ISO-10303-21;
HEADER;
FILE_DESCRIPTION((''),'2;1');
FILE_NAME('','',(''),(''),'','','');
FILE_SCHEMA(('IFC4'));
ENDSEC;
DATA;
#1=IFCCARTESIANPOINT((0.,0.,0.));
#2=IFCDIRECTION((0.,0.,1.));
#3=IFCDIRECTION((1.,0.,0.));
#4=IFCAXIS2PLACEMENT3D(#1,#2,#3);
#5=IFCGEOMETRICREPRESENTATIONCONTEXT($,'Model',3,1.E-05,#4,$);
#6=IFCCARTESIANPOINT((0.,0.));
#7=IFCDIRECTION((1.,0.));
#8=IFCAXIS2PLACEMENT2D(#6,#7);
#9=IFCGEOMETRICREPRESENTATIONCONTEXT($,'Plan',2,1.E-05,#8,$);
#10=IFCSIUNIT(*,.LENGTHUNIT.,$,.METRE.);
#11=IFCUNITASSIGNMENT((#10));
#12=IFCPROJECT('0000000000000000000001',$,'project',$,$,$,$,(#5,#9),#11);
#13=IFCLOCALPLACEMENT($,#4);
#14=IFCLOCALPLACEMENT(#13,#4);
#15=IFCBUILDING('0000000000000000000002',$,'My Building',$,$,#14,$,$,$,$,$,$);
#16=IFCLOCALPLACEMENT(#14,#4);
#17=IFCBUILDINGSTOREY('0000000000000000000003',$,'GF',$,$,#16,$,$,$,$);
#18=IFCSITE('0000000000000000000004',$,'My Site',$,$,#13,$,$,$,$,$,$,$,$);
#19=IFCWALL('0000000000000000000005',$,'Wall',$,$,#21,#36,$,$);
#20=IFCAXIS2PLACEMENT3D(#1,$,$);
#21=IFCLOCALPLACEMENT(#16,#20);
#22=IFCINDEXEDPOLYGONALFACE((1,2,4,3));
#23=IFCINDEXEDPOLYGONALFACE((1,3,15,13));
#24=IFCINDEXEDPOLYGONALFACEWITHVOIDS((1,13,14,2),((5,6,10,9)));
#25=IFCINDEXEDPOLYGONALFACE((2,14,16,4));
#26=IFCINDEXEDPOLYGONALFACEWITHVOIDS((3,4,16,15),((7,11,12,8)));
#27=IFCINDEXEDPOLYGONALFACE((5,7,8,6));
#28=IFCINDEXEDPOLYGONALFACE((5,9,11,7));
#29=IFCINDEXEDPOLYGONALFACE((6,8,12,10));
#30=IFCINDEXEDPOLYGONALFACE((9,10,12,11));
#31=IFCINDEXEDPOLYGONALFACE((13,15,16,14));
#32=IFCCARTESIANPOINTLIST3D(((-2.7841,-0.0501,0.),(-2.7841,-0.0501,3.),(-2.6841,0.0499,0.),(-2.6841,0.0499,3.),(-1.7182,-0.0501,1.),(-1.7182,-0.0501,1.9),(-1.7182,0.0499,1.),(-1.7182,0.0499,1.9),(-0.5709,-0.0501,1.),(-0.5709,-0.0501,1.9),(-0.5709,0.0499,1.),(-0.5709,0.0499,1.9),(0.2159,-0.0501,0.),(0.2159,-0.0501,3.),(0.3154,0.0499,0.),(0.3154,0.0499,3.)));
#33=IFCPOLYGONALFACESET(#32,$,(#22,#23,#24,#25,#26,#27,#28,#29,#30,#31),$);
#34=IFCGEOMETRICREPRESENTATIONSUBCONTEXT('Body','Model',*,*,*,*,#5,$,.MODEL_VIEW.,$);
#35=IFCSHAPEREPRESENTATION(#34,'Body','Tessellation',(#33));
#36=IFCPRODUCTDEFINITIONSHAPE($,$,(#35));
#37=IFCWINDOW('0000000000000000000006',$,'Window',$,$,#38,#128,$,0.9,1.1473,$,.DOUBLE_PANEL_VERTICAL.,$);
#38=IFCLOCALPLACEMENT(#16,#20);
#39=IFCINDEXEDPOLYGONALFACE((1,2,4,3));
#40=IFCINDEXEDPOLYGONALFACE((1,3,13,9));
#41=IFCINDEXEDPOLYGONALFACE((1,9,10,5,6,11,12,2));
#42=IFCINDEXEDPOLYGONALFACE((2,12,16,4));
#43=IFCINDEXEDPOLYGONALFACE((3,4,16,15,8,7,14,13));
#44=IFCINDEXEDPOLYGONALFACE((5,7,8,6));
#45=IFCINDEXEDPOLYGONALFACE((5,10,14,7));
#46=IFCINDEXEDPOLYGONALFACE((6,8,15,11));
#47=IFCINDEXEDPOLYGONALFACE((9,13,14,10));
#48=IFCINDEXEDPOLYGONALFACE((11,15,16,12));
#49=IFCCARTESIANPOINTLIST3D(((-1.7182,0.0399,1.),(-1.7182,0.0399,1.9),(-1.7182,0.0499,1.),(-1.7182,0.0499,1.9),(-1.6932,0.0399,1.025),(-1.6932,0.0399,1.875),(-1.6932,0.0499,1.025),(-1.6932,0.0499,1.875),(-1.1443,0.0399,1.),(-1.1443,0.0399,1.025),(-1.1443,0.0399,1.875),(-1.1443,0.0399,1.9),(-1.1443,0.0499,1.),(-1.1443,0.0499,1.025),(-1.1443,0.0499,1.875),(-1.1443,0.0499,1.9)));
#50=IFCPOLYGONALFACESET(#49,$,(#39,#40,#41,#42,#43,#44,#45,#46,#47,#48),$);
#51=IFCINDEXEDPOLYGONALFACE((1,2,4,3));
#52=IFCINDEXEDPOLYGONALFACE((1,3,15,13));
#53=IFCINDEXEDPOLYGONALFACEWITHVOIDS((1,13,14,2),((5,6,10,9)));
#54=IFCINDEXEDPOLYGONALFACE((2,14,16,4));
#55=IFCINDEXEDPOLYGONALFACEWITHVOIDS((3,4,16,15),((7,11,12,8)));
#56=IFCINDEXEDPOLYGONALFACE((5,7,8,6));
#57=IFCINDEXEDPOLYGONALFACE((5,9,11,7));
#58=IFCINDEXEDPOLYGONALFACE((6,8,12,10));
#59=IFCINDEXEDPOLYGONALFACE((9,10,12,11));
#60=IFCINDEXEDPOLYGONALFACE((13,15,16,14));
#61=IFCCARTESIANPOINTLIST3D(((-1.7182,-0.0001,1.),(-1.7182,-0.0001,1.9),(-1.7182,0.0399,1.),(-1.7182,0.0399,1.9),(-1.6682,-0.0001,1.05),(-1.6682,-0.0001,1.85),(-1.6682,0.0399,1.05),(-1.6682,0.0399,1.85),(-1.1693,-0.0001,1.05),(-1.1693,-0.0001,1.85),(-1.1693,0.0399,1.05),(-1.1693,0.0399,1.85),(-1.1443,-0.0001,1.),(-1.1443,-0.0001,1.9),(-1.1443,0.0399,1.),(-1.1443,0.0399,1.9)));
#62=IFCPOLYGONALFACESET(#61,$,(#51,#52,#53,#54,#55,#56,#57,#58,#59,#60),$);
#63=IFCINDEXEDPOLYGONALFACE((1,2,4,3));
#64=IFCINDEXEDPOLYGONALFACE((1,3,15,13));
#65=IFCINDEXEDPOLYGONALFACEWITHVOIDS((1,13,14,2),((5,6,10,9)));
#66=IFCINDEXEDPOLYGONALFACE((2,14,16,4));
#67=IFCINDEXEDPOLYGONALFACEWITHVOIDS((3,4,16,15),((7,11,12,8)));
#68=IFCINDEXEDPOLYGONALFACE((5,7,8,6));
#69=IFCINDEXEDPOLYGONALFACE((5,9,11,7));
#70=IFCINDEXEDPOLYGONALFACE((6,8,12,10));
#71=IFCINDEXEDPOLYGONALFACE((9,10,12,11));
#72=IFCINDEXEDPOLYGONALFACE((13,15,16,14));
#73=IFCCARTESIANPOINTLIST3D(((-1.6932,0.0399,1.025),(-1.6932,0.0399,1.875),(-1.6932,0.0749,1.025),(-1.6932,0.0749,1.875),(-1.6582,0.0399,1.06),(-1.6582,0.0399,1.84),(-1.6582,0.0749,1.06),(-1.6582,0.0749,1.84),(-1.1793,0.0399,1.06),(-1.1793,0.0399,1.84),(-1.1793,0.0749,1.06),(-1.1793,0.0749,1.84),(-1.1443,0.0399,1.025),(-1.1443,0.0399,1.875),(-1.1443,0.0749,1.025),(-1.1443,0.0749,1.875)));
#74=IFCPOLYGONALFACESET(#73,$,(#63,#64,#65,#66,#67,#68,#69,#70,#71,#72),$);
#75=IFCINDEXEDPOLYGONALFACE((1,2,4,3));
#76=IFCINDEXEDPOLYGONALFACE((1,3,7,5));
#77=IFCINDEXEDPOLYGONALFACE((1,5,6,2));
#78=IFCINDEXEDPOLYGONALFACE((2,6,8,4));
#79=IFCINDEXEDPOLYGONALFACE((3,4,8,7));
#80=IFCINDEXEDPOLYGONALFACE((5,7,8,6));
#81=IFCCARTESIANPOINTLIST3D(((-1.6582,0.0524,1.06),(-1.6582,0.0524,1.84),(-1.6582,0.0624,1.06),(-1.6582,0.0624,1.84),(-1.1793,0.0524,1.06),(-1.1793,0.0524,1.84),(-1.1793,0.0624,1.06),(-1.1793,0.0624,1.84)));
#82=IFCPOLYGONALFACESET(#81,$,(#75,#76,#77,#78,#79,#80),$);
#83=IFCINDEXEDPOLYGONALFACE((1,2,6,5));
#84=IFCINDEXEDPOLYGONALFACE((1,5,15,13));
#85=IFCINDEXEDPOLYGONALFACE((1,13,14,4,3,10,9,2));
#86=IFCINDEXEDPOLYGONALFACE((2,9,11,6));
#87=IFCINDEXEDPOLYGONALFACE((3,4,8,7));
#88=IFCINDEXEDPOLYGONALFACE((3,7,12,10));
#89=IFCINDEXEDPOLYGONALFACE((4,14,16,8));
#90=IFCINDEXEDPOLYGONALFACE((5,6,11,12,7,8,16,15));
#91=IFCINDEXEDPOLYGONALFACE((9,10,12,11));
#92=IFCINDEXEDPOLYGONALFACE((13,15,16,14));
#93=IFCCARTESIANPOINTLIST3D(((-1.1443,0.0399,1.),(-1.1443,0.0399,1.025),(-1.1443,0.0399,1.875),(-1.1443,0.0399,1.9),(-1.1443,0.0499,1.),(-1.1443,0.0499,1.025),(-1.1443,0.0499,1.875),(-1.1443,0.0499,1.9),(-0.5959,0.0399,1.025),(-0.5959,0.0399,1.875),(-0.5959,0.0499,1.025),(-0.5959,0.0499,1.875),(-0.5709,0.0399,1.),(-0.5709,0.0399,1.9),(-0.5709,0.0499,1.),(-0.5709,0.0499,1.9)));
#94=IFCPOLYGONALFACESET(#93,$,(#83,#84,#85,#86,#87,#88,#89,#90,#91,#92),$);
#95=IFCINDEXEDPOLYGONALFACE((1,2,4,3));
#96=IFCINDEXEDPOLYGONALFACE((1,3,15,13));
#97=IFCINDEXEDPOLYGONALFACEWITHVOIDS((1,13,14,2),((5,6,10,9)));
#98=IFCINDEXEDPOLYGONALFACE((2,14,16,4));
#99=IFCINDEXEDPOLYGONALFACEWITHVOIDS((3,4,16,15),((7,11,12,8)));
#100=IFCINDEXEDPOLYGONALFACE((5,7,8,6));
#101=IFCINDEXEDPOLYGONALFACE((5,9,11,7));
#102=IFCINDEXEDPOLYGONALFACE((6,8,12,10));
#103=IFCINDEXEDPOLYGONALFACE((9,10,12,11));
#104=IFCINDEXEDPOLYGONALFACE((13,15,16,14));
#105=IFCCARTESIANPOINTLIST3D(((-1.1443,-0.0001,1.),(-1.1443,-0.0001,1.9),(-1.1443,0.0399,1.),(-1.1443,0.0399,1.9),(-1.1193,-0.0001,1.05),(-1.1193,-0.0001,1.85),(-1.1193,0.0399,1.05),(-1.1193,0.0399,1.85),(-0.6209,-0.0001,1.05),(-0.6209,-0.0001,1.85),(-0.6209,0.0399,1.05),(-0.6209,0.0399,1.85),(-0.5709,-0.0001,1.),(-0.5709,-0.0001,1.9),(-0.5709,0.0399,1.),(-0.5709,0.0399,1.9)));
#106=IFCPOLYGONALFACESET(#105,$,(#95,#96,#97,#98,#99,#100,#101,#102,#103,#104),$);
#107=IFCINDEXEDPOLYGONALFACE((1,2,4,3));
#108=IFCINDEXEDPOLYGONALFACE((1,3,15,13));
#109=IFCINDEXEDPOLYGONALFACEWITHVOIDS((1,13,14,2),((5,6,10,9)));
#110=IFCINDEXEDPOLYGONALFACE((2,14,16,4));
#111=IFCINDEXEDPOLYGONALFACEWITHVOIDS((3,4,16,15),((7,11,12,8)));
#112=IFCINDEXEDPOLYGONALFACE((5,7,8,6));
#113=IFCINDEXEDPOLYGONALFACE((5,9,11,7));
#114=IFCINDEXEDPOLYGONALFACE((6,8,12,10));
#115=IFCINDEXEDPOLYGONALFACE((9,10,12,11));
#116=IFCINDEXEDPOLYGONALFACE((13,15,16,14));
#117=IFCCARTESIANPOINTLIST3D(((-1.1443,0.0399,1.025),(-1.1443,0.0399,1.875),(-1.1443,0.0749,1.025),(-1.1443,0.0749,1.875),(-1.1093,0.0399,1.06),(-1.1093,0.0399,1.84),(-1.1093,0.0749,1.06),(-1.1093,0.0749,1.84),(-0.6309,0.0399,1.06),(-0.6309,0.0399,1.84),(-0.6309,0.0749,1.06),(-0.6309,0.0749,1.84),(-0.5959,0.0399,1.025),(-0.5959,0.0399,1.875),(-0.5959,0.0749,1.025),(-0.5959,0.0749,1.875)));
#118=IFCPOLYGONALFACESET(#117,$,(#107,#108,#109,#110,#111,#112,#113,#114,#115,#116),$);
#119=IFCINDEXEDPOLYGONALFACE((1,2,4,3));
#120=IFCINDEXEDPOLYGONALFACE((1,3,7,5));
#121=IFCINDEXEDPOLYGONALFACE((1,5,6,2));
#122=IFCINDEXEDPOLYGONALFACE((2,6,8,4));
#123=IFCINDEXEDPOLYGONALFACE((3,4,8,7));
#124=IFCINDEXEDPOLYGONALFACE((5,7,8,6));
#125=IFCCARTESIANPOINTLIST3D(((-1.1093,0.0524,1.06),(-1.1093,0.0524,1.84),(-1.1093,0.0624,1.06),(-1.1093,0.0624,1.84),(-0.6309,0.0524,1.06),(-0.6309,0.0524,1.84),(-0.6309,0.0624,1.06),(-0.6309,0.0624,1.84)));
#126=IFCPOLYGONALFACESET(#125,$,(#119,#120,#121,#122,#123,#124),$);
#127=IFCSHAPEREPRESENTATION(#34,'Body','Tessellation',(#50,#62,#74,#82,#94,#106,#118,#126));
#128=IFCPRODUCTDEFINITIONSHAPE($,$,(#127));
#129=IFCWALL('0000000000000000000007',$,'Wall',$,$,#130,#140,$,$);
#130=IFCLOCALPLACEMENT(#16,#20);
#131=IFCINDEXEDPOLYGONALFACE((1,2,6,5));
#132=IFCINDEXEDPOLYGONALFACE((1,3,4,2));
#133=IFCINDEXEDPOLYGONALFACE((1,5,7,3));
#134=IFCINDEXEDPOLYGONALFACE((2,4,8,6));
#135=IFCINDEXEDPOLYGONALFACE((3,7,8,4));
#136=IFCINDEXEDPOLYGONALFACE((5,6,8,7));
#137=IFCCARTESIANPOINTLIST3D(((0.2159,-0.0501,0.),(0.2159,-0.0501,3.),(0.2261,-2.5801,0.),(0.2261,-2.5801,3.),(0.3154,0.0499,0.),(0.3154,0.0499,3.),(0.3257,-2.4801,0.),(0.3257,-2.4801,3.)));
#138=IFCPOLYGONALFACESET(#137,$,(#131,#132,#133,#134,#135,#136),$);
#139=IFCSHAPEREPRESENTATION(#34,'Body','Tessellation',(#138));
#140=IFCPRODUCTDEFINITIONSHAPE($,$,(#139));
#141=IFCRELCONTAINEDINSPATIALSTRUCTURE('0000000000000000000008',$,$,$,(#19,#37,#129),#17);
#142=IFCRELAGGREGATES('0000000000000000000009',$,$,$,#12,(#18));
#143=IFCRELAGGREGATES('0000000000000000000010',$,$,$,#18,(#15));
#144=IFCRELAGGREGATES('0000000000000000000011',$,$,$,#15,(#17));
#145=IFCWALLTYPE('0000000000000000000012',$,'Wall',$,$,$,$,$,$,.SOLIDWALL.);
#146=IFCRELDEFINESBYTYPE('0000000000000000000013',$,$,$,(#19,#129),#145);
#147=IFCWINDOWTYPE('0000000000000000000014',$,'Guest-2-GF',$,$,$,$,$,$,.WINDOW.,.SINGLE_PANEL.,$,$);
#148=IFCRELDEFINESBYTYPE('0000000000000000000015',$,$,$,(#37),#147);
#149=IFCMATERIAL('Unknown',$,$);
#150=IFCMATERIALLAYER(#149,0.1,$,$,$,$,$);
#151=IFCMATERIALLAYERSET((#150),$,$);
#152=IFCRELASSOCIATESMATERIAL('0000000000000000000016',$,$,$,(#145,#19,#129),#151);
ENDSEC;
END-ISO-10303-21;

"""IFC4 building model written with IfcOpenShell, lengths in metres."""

from ifc_helpers import new_model, entity, si_unit, frame, origin_with_axes, origin_2d_with_axis, place, context, subcontext, project, spatial, line, indexed_curve, outline, extrude, shape, source, transform, mapped, material, layer, layer_set, layer_usage, type_object, type_shapes, element, fill, save


model = new_model("IFC4")

# Units and contexts
model_context = context("Model", 3, precision=1e-05, world=origin_with_axes())
plan_context = context("Plan", 2, precision=1e-05, world=origin_2d_with_axis())
body_context_1 = subcontext(model_context, "Body", "Model", "MODEL_VIEW")
body_context_2 = subcontext(plan_context, "Body", "Plan", "PLAN_VIEW")
ifc_project = project(units=[si_unit("LENGTHUNIT", "METRE")], contexts=[model_context, plan_context])

# Site, building, storey
site_placement = place(None, origin_with_axes())
site = spatial("IfcSite", under=ifc_project, at=site_placement, Name="My Site")
building_placement = place(site_placement, origin_with_axes())
building = spatial("IfcBuilding", under=site, at=building_placement, Name="My Building")
storey_placement = place(building_placement, origin_with_axes())
storey = spatial("IfcBuildingStorey", under=building, at=storey_placement, Name="GF")

# Shared definitions
ifc_material = material(Name="Unknown")

# Shared definitions
ifc_layer_1 = layer(ifc_material, 0.1)
ifc_layer_set_1 = layer_set([ifc_layer_1])
wall_type = type_object("IfcWallType", Name="Wall", PredefinedType="SOLIDWALL", material=ifc_layer_set_1)

# Wall, opening, window
ifc_layer_usage_1 = layer_usage(ifc_layer_set_1, "AXIS2", "POSITIVE", 0.0)
wall_1_placement = place(storey_placement, frame((-2.7841, -0.0501, 0.0), z_axis=(0.0, 0.0, 1.0), x_axis=(1.0, 0.0, 0.0)))
wall_1 = element("IfcWall", 1, at=wall_1_placement, inside=storey, type_object=wall_type, material=ifc_layer_usage_1, Name="Wall", context=body_context_1, shape_type="SweptSolid", body=[
    extrude(outline(indexed_curve([(0.0, 0.0), (0.1, 0.1), (3.0996, 0.1), (3.0, 0.0)], segments=[line(1, 2, 3, 4, 1)])), origin_with_axes(), (0.0, 0.0, 1.0), 3.0),
])
shared_shape_1 = source(origin_with_axes(), body_context_1, "Body", "SweptSolid", [
    extrude(outline(indexed_curve([(0.0, 0.0), (1.1473, 0.0), (1.1473, 0.9), (0.0, 0.9)], segments=[line(1, 2, 3, 4, 1)])), frame((0.0, -0.6, 0.0), z_axis=(0.0, -1.0, 0.0), x_axis=(1.0, 0.0, 0.0)), (0.0, 0.0, -1.0), 1.2),
])
opening_1_placement = place(wall_1_placement, frame((1.066, 0.0, 1.0), z_axis=(0.0, 0.0, 1.0), x_axis=(1.0, 0.0, 0.0)))
opening_1 = element("IfcOpeningElement", 2, at=opening_1_placement, cuts=wall_1, PredefinedType="OPENING", context=body_context_1, shape_type="MappedRepresentation", body=[
    mapped(shared_shape_1, transform((0.0, 0.0, 0.0), x_axis=(1.0, 0.0, 0.0), y_axis=(0.0, 1.0, 0.0), z_axis=(0.0, 0.0, 1.0), scale=1.0)),
])
window_type_1 = type_object("IfcWindowType", Name="Guest-2-GF", PartitioningType="SINGLE_PANEL", PredefinedType="WINDOW")
shared_shape_2 = source(origin_with_axes(), body_context_1, "Body", "SweptSolid", [
    extrude(outline(indexed_curve([(0.5739, 0.0), (0.0, 0.0), (0.0, 0.9), (0.5739, 0.9), (0.5739, 0.875), (0.025, 0.875), (0.025, 0.025), (0.5739, 0.025)], segments=[line(1, 2, 3, 4, 5, 6, 7, 8, 1)])), frame((0.0, 0.09, 0.0), z_axis=(0.0, -1.0, 0.0), x_axis=(1.0, 0.0, 0.0)), (0.0, 0.0, -1.0), 0.01),
    extrude(outline(indexed_curve([(0.0, 0.0), (0.5739, 0.0), (0.5739, 0.9), (0.0, 0.9)], segments=[line(1, 2, 3, 4, 1)]), holes=[indexed_curve([(0.05, 0.05), (0.5489, 0.05), (0.5489, 0.85), (0.05, 0.85)], segments=[line(1, 2, 3, 4, 1)])]), frame((0.0, 0.05, 0.0), z_axis=(0.0, -1.0, 0.0), x_axis=(1.0, 0.0, 0.0)), (0.0, 0.0, -1.0), 0.04),
    extrude(outline(indexed_curve([(0.0, 0.0), (0.5489, 0.0), (0.5489, 0.85), (0.0, 0.85)], segments=[line(1, 2, 3, 4, 1)]), holes=[indexed_curve([(0.035, 0.035), (0.5139, 0.035), (0.5139, 0.815), (0.035, 0.815)], segments=[line(1, 2, 3, 4, 1)])]), frame((0.025, 0.09, 0.025), z_axis=(0.0, -1.0, 0.0), x_axis=(1.0, 0.0, 0.0)), (0.0, 0.0, -1.0), 0.035),
    extrude(outline(indexed_curve([(0.035, 0.035), (0.5139, 0.035), (0.5139, 0.815), (0.035, 0.815)], segments=[line(1, 2, 3, 4, 1)])), frame((0.025, 0.1025, 0.025), z_axis=(0.0, -1.0, 0.0), x_axis=(1.0, 0.0, 0.0)), (0.0, 0.0, -1.0), 0.01),
    extrude(outline(indexed_curve([(0.0, 0.9), (0.5733, 0.9), (0.5733, 0.0), (0.0, 0.0), (0.0, 0.025), (0.5483, 0.025), (0.5483, 0.875), (0.0, 0.875)], segments=[line(1, 2, 3, 4, 5, 6, 7, 8, 1)])), frame((0.5739, 0.09, 0.0), z_axis=(0.0, -1.0, 0.0), x_axis=(1.0, 0.0, 0.0)), (0.0, 0.0, -1.0), 0.01),
    extrude(outline(indexed_curve([(0.0, 0.0), (0.5733, 0.0), (0.5733, 0.9), (0.0, 0.9)], segments=[line(1, 2, 3, 4, 1)]), holes=[indexed_curve([(0.025, 0.05), (0.5233, 0.05), (0.5233, 0.85), (0.025, 0.85)], segments=[line(1, 2, 3, 4, 1)])]), frame((0.5739, 0.05, 0.0), z_axis=(0.0, -1.0, 0.0), x_axis=(1.0, 0.0, 0.0)), (0.0, 0.0, -1.0), 0.04),
    extrude(outline(indexed_curve([(0.0, 0.0), (0.5483, 0.0), (0.5483, 0.85), (0.0, 0.85)], segments=[line(1, 2, 3, 4, 1)]), holes=[indexed_curve([(0.035, 0.035), (0.5133, 0.035), (0.5133, 0.815), (0.035, 0.815)], segments=[line(1, 2, 3, 4, 1)])]), frame((0.5739, 0.09, 0.025), z_axis=(0.0, -1.0, 0.0), x_axis=(1.0, 0.0, 0.0)), (0.0, 0.0, -1.0), 0.035),
    extrude(outline(indexed_curve([(0.035, 0.035), (0.5133, 0.035), (0.5133, 0.815), (0.035, 0.815)], segments=[line(1, 2, 3, 4, 1)])), frame((0.5739, 0.1025, 0.025), z_axis=(0.0, -1.0, 0.0), x_axis=(1.0, 0.0, 0.0)), (0.0, 0.0, -1.0), 0.01),
])
shared_shape_3 = source(origin_with_axes(), body_context_2, "Body", "Curve2D", [
    entity("IfcIndexedPolyCurve", entity("IfcCartesianPointList2D", [[0.05, 0.05], [0.5489, 0.05]])),
    entity("IfcIndexedPolyCurve", entity("IfcCartesianPointList2D", [[0.0, 0.1], [0.025, 0.1], [0.025, 0.09], [0.05, 0.09], [0.05, 0.05], [0.0, 0.05]]), [entity("IfcLineIndex", [1, 2, 3, 4, 5, 6, 1])]),
    entity("IfcIndexedPolyCurve", entity("IfcCartesianPointList2D", [[0.5739, 0.1], [0.5739, 0.1], [0.5739, 0.09], [0.5489, 0.09], [0.5489, 0.05], [0.5739, 0.05]])),
    entity("IfcIndexedPolyCurve", entity("IfcCartesianPointList2D", [[0.025, 0.09], [0.06, 0.09], [0.06, 0.125], [0.025, 0.125]]), [entity("IfcLineIndex", [1, 2, 3, 4, 1])]),
    entity("IfcIndexedPolyCurve", entity("IfcCartesianPointList2D", [[0.5739, 0.09], [0.5389, 0.09], [0.5389, 0.125], [0.5739, 0.125]]), [entity("IfcLineIndex", [1, 2, 3, 4, 1])]),
    entity("IfcIndexedPolyCurve", entity("IfcCartesianPointList2D", [[0.06, 0.09], [0.5389, 0.09]])),
    entity("IfcIndexedPolyCurve", entity("IfcCartesianPointList2D", [[0.06, 0.125], [0.5389, 0.125]])),
    entity("IfcIndexedPolyCurve", entity("IfcCartesianPointList2D", [[0.06, 0.1075], [0.5389, 0.1075]])),
    entity("IfcIndexedPolyCurve", entity("IfcCartesianPointList2D", [[0.5989, 0.05], [1.0973, 0.05]])),
    entity("IfcIndexedPolyCurve", entity("IfcCartesianPointList2D", [[0.5739, 0.1], [0.5739, 0.1], [0.5739, 0.09], [0.5989, 0.09], [0.5989, 0.05], [0.5739, 0.05]])),
    entity("IfcIndexedPolyCurve", entity("IfcCartesianPointList2D", [[1.1473, 0.1], [1.1223, 0.1], [1.1223, 0.09], [1.0973, 0.09], [1.0973, 0.05], [1.1473, 0.05]]), [entity("IfcLineIndex", [1, 2, 3, 4, 5, 6, 1])]),
    entity("IfcIndexedPolyCurve", entity("IfcCartesianPointList2D", [[0.5739, 0.09], [0.6089, 0.09], [0.6089, 0.125], [0.5739, 0.125]]), [entity("IfcLineIndex", [1, 2, 3, 4, 1])]),
    entity("IfcIndexedPolyCurve", entity("IfcCartesianPointList2D", [[1.1223, 0.09], [1.0873, 0.09], [1.0873, 0.125], [1.1223, 0.125]]), [entity("IfcLineIndex", [1, 2, 3, 4, 1])]),
    entity("IfcIndexedPolyCurve", entity("IfcCartesianPointList2D", [[0.6089, 0.09], [1.0873, 0.09]])),
    entity("IfcIndexedPolyCurve", entity("IfcCartesianPointList2D", [[0.6089, 0.125], [1.0873, 0.125]])),
    entity("IfcIndexedPolyCurve", entity("IfcCartesianPointList2D", [[0.6089, 0.1075], [1.0873, 0.1075]])),
])
type_shapes(window_type_1, [shared_shape_2, shared_shape_3])
window_1_placement = place(opening_1_placement, origin_with_axes())
window_1 = element("IfcWindow", 3, at=window_1_placement, inside=storey, type_object=window_type_1, Name="Window", OverallHeight=0.9, OverallWidth=1.1473, PartitioningType="DOUBLE_PANEL_VERTICAL", shapes=[
    shape(body_context_1, "Body", "MappedRepresentation", [mapped(shared_shape_2, transform((0.0, 0.0, 0.0), x_axis=(1.0, 0.0, 0.0), y_axis=(0.0, 1.0, 0.0), z_axis=(0.0, 0.0, 1.0), scale=1.0))]),
    shape(body_context_2, "Body", "MappedRepresentation", [mapped(shared_shape_3, transform((0.0, 0.0, 0.0), x_axis=(1.0, 0.0, 0.0), y_axis=(0.0, 1.0, 0.0), z_axis=(0.0, 0.0, 1.0), scale=1.0))]),
])
fill(opening_1, window_1)

# Wall
ifc_layer_usage_2 = layer_usage(ifc_layer_set_1, "AXIS2", "POSITIVE", 0.0)
wall_2_placement = place(storey_placement, frame((0.2159, -0.0501, 0.0), z_axis=(0.0, 0.0, 1.0), x_axis=(0.004067, -0.999992, 0.0)))
element("IfcWall", 4, at=wall_2_placement, inside=storey, type_object=wall_type, material=ifc_layer_usage_2, Name="Wall", context=body_context_1, shape_type="SweptSolid", body=[
    extrude(outline(indexed_curve([(0.0, 0.0), (-0.0996, 0.1), (2.4304, 0.1), (2.53, 0.0)], segments=[line(1, 2, 3, 4, 1)])), origin_with_axes(), (0.0, 0.0, 1.0), 3.0),
])

save(model, "model.ifc")
